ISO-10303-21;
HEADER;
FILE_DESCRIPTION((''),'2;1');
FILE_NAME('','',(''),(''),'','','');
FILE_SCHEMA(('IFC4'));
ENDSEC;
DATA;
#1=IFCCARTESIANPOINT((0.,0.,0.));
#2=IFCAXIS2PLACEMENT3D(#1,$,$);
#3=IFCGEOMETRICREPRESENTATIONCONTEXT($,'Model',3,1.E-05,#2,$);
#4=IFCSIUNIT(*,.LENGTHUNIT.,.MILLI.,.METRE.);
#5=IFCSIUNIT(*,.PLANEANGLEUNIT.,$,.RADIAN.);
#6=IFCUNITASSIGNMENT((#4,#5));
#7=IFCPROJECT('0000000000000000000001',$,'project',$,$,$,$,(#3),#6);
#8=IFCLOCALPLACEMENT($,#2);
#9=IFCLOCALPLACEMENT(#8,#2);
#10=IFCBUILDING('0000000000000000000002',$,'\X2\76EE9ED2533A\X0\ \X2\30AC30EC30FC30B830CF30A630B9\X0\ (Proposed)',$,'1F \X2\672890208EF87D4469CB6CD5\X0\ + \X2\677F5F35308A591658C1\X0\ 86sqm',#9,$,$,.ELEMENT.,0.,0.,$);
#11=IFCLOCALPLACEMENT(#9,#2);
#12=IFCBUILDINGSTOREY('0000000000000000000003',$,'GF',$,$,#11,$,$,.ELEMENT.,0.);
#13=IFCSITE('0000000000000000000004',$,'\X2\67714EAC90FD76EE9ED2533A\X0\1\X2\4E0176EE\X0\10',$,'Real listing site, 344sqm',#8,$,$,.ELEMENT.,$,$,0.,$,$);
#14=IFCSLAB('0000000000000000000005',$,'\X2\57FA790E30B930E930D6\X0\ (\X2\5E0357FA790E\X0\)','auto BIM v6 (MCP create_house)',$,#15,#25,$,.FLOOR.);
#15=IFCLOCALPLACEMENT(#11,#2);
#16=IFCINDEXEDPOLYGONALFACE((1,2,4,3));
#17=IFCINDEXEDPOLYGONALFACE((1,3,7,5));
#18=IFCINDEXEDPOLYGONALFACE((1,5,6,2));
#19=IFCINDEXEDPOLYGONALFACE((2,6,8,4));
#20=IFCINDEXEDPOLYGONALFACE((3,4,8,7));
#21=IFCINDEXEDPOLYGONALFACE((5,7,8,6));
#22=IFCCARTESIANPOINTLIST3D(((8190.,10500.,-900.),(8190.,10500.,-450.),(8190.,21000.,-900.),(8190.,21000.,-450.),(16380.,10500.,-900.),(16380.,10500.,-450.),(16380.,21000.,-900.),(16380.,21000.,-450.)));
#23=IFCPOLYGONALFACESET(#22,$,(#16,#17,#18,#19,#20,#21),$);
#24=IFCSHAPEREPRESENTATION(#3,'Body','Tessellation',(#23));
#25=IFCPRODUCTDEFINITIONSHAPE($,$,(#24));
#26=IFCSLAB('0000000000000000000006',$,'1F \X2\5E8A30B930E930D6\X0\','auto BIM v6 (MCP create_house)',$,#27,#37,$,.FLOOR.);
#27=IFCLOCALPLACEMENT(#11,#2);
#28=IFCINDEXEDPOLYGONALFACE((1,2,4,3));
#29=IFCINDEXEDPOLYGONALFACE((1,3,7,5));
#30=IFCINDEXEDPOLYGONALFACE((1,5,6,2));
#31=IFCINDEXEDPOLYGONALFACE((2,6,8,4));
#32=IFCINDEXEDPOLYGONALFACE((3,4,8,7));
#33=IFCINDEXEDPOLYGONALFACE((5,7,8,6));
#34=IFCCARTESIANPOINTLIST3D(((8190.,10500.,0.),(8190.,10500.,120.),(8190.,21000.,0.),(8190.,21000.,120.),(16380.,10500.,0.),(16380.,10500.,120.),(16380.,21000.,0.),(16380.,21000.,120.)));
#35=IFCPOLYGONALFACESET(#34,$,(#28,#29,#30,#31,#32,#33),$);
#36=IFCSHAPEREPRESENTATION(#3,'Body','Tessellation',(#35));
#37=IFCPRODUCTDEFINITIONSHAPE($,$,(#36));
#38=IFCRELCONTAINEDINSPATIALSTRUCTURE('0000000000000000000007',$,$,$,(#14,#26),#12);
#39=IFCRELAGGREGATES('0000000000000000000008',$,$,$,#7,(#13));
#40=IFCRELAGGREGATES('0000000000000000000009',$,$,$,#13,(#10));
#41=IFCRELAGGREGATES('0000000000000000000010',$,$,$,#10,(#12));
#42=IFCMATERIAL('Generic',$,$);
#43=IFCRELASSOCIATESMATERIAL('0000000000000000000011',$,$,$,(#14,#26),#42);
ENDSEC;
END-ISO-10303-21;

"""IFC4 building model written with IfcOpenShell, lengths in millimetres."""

from ifc_helpers import new_model, si_unit, frame, frame_2d, origin, place, context, project, spatial, rectangle, extrude, material, element, save


model = new_model("IFC4")

# Units and contexts
model_context = context("Model", 3, precision=1e-05, world=origin())
ifc_project = project(units=[si_unit("LENGTHUNIT", "METRE", prefix="MILLI"), si_unit("PLANEANGLEUNIT", "RADIAN")], contexts=[model_context])

# Site, building, storey
site_placement = place(None, origin())
site = spatial("IfcSite", under=ifc_project, at=site_placement, Name="東京都目黒区1丁目10", ObjectType="Real listing site, 344sqm", CompositionType="ELEMENT", RefElevation=0.0)
building_placement = place(site_placement, origin())
building = spatial("IfcBuilding", under=site, at=building_placement, Name="目黒区 ガレージハウス (Proposed)", ObjectType="1F 木造軸組構法 + 板張り外壁 86sqm", CompositionType="ELEMENT", ElevationOfRefHeight=0.0, ElevationOfTerrain=0.0)
storey_placement = place(building_placement, origin())
storey = spatial("IfcBuildingStorey", under=building, at=storey_placement, Name="GF", CompositionType="ELEMENT", Elevation=0.0)

# Slabs
ifc_material = material(Name="Generic")
slab_1_placement = place(storey_placement, frame((4095.0, 5250.0, -450.0)))
element("IfcSlab", 1, at=slab_1_placement, inside=storey, material=ifc_material, Name="基礎スラブ (布基礎)", Description="auto BIM v6 (MCP create_house)", PredefinedType="FLOOR", context=model_context, shape_type="SweptSolid", body=[
    extrude(rectangle(XDim=8190.0, YDim=10500.0, at=frame_2d((4095.0, 5250.0))), frame((4095.0, 5250.0, -450.0)), (0.0, 0.0, 1.0), 450.0),
])
slab_2_placement = place(storey_placement, frame((4095.0, 5250.0, 0.0)))
element("IfcSlab", 2, at=slab_2_placement, inside=storey, material=ifc_material, Name="1F 床スラブ", Description="auto BIM v6 (MCP create_house)", PredefinedType="FLOOR", context=model_context, shape_type="SweptSolid", body=[
    extrude(rectangle(XDim=8190.0, YDim=10500.0, at=frame_2d((4095.0, 5250.0))), frame((4095.0, 5250.0, 0.0)), (0.0, 0.0, 1.0), 120.0),
])

save(model, "model.ifc")
